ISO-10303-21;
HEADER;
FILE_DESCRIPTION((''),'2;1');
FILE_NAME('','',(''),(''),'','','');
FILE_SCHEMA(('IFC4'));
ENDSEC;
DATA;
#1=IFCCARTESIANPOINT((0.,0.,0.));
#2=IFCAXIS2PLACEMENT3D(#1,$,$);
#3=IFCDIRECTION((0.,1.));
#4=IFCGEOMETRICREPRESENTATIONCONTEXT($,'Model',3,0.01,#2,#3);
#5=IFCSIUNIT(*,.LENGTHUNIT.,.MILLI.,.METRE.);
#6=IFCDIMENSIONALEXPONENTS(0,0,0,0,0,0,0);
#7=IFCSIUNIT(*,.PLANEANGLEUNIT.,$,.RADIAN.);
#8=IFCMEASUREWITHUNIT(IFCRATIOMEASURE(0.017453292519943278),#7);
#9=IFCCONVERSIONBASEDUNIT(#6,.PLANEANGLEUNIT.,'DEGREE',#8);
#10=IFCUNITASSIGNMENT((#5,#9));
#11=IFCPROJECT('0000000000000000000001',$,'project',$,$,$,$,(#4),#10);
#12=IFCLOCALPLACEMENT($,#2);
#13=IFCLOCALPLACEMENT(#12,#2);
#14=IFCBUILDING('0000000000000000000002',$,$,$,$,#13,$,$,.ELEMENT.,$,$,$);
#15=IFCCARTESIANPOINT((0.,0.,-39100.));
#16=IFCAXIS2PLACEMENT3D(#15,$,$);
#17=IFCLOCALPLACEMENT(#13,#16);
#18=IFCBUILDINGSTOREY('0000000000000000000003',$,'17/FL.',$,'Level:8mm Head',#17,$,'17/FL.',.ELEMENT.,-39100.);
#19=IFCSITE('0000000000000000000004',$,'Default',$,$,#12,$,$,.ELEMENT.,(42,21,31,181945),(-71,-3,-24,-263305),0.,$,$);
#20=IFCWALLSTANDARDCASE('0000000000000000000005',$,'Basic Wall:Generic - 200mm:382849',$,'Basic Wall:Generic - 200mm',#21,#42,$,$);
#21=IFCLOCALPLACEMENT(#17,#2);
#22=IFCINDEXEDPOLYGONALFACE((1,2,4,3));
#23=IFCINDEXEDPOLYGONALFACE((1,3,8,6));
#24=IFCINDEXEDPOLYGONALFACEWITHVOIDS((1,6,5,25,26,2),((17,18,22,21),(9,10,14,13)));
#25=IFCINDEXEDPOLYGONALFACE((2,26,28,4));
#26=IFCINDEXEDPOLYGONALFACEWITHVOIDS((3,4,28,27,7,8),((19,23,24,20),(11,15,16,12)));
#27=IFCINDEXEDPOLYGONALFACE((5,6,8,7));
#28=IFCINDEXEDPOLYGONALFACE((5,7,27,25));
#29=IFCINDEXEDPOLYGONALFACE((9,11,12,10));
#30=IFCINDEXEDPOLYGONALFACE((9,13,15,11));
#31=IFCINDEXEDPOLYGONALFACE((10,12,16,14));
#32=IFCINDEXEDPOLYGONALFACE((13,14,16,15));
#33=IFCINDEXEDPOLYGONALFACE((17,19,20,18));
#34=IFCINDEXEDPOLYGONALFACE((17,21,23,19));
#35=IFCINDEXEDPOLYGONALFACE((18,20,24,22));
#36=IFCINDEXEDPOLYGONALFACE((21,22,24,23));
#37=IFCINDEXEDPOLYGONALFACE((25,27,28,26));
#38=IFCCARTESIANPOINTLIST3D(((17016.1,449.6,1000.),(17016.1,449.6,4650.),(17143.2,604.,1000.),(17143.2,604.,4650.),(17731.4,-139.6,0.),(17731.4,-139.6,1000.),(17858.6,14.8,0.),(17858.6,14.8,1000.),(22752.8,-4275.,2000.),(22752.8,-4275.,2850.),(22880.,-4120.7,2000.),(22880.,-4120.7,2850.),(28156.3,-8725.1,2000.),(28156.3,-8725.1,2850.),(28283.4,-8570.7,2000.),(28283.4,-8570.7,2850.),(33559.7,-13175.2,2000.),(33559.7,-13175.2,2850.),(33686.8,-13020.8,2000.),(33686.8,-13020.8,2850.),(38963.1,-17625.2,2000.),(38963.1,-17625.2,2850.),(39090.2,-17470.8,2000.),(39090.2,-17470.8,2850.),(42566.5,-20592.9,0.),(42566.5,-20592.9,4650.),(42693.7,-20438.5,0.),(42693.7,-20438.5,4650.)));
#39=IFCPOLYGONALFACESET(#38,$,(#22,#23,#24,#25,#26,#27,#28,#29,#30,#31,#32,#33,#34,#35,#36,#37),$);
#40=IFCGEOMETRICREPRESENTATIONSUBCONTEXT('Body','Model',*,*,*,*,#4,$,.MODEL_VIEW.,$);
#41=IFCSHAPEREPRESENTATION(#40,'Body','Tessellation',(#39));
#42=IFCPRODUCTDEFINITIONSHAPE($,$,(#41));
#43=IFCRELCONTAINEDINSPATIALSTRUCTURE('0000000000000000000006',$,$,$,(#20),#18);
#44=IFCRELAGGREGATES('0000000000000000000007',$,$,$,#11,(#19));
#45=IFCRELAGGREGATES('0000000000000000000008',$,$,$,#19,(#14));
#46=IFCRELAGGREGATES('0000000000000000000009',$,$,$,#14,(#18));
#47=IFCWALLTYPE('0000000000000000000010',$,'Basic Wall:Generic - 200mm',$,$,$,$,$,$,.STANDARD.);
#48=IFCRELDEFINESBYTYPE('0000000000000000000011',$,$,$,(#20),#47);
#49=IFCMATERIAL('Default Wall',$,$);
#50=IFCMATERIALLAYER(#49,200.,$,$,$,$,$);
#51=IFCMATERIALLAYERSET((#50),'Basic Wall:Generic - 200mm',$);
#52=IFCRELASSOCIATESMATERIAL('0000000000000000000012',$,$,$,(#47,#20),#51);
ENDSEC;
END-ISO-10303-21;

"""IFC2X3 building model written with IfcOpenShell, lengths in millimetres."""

from ifc_helpers import new_model, entity, si_unit, converted_unit, direction, frame, frame_2d, origin, origin_2d_with_axis, place, context, subcontext, project, spatial, rectangle, extrude, material, layer, layer_set, layer_usage, type_object, element, save


model = new_model("IFC2X3")

# Units and contexts
model_context = context("Model", 3, precision=0.01, world=origin(), true_north=direction((0.0, 1.0)))
body_context = subcontext(model_context, "Body", "Model", "MODEL_VIEW")
ifc_project = project(units=[si_unit("LENGTHUNIT", "METRE", prefix="MILLI"), converted_unit("PLANEANGLEUNIT", "DEGREE", entity("IfcRatioMeasure", 0.017453292519943278), si_unit("PLANEANGLEUNIT", "RADIAN"), dimensions=[0, 0, 0, 0, 0, 0, 0])], contexts=[model_context])

# Site, building, storey
site_placement = place(None, origin())
site = spatial("IfcSite", under=ifc_project, at=site_placement, Name="Default", CompositionType="ELEMENT", RefLatitude=(42, 21, 31, 181945), RefLongitude=(-71, -3, -24, -263305), RefElevation=0.0)
building_placement = place(site_placement, origin())
building = spatial("IfcBuilding", under=site, at=building_placement, CompositionType="ELEMENT")
storey_placement = place(building_placement, frame((0.0, 0.0, -39100.0)))
storey = spatial("IfcBuildingStorey", under=building, at=storey_placement, Name="17/FL.", ObjectType="Level:8mm Head", LongName="17/FL.", CompositionType="ELEMENT", Elevation=-39100.0)

# Wall, openings
ifc_material_1 = material(Name="Default Wall")
ifc_layer = layer(ifc_material_1, 200.0)
ifc_layer_set = layer_set([ifc_layer], Name="Basic Wall:Generic - 200mm")
ifc_layer_usage = layer_usage(ifc_layer_set, "AXIS2", "NEGATIVE", 100.0)
wall_type = type_object("IfcWallType", Name="Basic Wall:Generic - 200mm", PredefinedType="STANDARD", material=ifc_layer_set)
wall_1_placement = place(storey_placement, frame((42630.1, -20515.7, 0.0), z_axis=(0.0, 0.0, 1.0), x_axis=(-0.771917, 0.635723, 0.0)))
wall_1 = element("IfcWallStandardCase", 1, at=wall_1_placement, inside=storey, type_object=wall_type, material=ifc_layer_usage, Name="Basic Wall:Generic - 200mm:382849", ObjectType="Basic Wall:Generic - 200mm", context=body_context, shape_type="SweptSolid", body=[
    extrude(rectangle(XDim=33100.0, YDim=200.0, at=frame_2d((16550.0, 0.0), x_axis=(-1.0, 0.0))), origin(), (0.0, 0.0, 1.0), 4650.0),
])
opening_1_placement = place(wall_1_placement, origin())
element("IfcOpeningElement", 2, at=opening_1_placement, cuts=wall_1, ObjectType="Opening", context=body_context, shape_type="SweptSolid", body=[
    extrude(rectangle(XDim=850.0, YDim=7000.0, at=frame_2d((0.0, 0.0), x_axis=(1.0, 0.0))), frame((8168.1, -100.0, 2425.0), z_axis=(0.0, 1.0, 0.0), x_axis=(0.0, 0.0, -1.0)), (0.0, 0.0, 1.0), 200.0),
])
opening_2_placement = place(wall_1_placement, origin())
element("IfcOpeningElement", 3, at=opening_2_placement, cuts=wall_1, ObjectType="Opening", context=body_context, shape_type="SweptSolid", body=[
    extrude(rectangle(XDim=850.0, YDim=7000.0, at=origin_2d_with_axis()), frame((22168.1, -100.0, 2425.0), z_axis=(0.0, 1.0, 0.0), x_axis=(0.0, 0.0, -1.0)), (0.0, 0.0, 1.0), 200.0),
])
opening_3_placement = place(wall_1_placement, frame((45949.2, 11264.5, 0.0), z_axis=(0.0, 0.0, 1.0), x_axis=(-0.771917, -0.635723, 0.0)))
element("IfcOpeningElement", 4, at=opening_3_placement, cuts=wall_1, ObjectType="Opening", context=body_context, shape_type="SweptSolid", body=[
    extrude(rectangle(XDim=1000.0, YDim=1010.1, at=frame_2d((0.0, 0.0), x_axis=(1.0, 0.0))), frame((17476.8, 345.7, 500.0), z_axis=(-0.635723, -0.771917, 0.0), x_axis=(0.0, 0.0, -1.0)), (0.0, 0.0, 1.0), 1012.7),
])

save(model, "model.ifc")
